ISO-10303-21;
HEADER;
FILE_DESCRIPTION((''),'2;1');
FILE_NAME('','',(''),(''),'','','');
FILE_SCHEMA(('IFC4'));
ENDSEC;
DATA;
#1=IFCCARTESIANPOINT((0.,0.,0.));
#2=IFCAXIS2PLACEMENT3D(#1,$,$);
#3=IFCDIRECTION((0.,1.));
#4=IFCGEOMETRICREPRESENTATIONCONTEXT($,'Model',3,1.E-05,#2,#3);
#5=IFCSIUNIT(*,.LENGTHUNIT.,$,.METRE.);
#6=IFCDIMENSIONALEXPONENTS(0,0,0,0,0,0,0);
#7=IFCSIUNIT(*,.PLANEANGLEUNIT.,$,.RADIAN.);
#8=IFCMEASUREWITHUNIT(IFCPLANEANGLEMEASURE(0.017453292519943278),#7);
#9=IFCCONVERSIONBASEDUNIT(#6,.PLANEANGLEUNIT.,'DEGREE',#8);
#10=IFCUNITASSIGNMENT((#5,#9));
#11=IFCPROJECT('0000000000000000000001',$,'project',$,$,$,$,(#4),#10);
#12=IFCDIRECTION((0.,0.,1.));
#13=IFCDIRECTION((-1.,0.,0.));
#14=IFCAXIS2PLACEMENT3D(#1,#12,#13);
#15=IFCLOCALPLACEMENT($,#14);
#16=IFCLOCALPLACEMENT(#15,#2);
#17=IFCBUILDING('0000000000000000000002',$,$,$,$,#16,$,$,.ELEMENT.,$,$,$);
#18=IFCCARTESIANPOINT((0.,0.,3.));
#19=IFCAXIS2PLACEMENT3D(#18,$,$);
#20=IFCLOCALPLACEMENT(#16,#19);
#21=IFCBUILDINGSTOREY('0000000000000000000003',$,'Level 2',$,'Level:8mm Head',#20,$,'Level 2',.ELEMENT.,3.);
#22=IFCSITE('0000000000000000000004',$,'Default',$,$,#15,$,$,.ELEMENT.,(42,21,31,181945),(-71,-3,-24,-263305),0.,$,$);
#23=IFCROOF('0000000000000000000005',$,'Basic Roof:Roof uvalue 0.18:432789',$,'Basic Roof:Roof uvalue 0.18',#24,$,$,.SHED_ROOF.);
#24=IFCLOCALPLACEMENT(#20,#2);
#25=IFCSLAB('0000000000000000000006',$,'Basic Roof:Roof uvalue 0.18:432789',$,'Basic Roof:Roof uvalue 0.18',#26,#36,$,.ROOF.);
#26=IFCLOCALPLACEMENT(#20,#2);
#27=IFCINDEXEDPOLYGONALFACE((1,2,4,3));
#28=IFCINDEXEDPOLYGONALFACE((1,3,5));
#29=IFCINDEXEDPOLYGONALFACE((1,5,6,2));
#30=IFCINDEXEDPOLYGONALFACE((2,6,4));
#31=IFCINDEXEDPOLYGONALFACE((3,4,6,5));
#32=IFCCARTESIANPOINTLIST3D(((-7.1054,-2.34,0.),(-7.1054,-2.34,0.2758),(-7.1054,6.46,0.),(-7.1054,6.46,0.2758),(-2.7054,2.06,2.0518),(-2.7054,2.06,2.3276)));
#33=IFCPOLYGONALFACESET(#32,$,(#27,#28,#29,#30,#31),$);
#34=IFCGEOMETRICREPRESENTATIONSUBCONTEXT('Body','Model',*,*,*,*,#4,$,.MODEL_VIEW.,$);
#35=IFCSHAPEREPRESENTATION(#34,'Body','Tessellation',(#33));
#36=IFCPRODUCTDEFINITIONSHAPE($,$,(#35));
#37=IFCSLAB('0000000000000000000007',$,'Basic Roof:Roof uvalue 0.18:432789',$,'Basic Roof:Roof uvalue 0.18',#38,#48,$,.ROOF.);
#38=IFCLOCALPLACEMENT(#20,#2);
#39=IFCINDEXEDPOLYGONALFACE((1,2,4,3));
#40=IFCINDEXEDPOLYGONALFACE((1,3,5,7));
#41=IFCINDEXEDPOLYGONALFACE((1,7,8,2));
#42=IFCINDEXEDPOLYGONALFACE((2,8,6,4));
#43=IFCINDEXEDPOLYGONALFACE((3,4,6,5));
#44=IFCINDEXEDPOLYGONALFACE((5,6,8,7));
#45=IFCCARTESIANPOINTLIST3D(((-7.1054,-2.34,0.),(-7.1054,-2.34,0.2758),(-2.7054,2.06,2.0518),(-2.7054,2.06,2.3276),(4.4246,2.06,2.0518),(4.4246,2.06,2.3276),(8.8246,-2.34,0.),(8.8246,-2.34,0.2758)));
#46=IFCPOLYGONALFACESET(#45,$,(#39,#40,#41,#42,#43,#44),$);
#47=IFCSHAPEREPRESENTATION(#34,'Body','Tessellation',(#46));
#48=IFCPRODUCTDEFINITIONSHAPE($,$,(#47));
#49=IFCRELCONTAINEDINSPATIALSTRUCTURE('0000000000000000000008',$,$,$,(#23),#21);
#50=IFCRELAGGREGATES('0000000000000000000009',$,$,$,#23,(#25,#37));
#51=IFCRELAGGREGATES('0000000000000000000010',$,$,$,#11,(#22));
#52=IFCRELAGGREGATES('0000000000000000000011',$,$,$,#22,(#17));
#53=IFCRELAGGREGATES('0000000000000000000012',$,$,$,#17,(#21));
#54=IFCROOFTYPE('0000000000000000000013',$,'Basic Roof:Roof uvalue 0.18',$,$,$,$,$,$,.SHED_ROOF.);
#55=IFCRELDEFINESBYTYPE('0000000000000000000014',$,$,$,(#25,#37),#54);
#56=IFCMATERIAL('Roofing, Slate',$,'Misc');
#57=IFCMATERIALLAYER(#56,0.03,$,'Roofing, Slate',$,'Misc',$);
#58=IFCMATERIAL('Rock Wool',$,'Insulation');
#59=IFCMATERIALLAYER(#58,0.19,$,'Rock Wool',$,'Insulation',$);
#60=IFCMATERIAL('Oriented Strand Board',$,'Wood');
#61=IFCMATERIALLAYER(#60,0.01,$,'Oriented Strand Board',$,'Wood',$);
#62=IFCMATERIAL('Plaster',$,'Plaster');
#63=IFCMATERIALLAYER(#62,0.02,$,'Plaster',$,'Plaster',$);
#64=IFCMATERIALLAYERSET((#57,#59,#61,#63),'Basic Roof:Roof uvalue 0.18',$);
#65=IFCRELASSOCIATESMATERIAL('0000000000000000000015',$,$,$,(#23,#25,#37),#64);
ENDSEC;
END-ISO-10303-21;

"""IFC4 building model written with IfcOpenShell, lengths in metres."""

from ifc_helpers import new_model, entity, si_unit, converted_unit, direction, frame, origin, place, context, subcontext, project, spatial, polyline, outline, extrude, material, layer, layer_set, type_object, element, aggregate, save


model = new_model("IFC4")

# Units and contexts
model_context = context("Model", 3, precision=1e-05, world=origin(), true_north=direction((0.0, 1.0)))
body_context = subcontext(model_context, "Body", "Model", "MODEL_VIEW")
ifc_project = project(units=[si_unit("LENGTHUNIT", "METRE"), converted_unit("PLANEANGLEUNIT", "DEGREE", entity("IfcPlaneAngleMeasure", 0.017453292519943278), si_unit("PLANEANGLEUNIT", "RADIAN"), dimensions=[0, 0, 0, 0, 0, 0, 0])], contexts=[model_context])

# Site, building, storey
site_placement = place(None, frame((0.0, 0.0, 0.0), z_axis=(0.0, 0.0, 1.0), x_axis=(-1.0, 0.0, 0.0)))
site = spatial("IfcSite", under=ifc_project, at=site_placement, Name="Default", CompositionType="ELEMENT", RefLatitude=(42, 21, 31, 181945), RefLongitude=(-71, -3, -24, -263305), RefElevation=0.0)
building_placement = place(site_placement, origin())
building = spatial("IfcBuilding", under=site, at=building_placement, CompositionType="ELEMENT")
storey_placement = place(building_placement, frame((0.0, 0.0, 3.0)))
storey = spatial("IfcBuildingStorey", under=building, at=storey_placement, Name="Level 2", ObjectType="Level:8mm Head", LongName="Level 2", CompositionType="ELEMENT", Elevation=3.0)

# Roof, slabs
ifc_material_1 = material(Name="Roofing, Slate", Category="Misc")
ifc_layer_1 = layer(ifc_material_1, 0.03, Name="Roofing, Slate", Category="Misc")
ifc_material_2 = material(Name="Rock Wool", Category="Insulation")
ifc_layer_2 = layer(ifc_material_2, 0.19, Name="Rock Wool", Category="Insulation")
ifc_material_3 = material(Name="Oriented Strand Board", Category="Wood")
ifc_layer_3 = layer(ifc_material_3, 0.01, Name="Oriented Strand Board", Category="Wood")
ifc_material_4 = material(Name="Plaster", Category="Plaster")
ifc_layer_4 = layer(ifc_material_4, 0.02, Name="Plaster", Category="Plaster")
ifc_layer_set = layer_set([ifc_layer_1, ifc_layer_2, ifc_layer_3, ifc_layer_4], Name="Basic Roof:Roof uvalue 0.18")
roof_placement = place(storey_placement, frame((-7.1054, -2.34, 0.0)))
roof = element("IfcRoof", 1, at=roof_placement, inside=storey, material=ifc_layer_set, Name="Basic Roof:Roof uvalue 0.18:432789", ObjectType="Basic Roof:Roof uvalue 0.18", PredefinedType="SHED_ROOF")
roof_type = type_object("IfcRoofType", Name="Basic Roof:Roof uvalue 0.18", PredefinedType="SHED_ROOF")
slab_1_placement = place(roof_placement, origin())
slab_1 = element("IfcSlab", 2, at=slab_1_placement, type_object=roof_type, material=ifc_layer_set, Name="Basic Roof:Roof uvalue 0.18:432789", ObjectType="Basic Roof:Roof uvalue 0.18", PredefinedType="ROOF", context=body_context, shape_type="SweptSolid", body=[
    extrude(outline(polyline([(-2.4274, 4.4), (-2.4274, -4.4), (2.4274, 0.0), (-2.4274, 4.4)])), frame((2.2, 4.4, 1.0259), z_axis=(-0.422618, 0.0, 0.906308), x_axis=(0.906308, 0.0, 0.422618)), (0.422618, 0.0, 0.906308), 0.2758),
])
slab_2_placement = place(roof_placement, origin())
slab_2 = element("IfcSlab", 3, at=slab_2_placement, type_object=roof_type, material=ifc_layer_set, Name="Basic Roof:Roof uvalue 0.18:432789", ObjectType="Basic Roof:Roof uvalue 0.18", PredefinedType="ROOF", context=body_context, shape_type="SweptSolid", body=[
    extrude(outline(polyline([(-7.965, -2.4274), (7.965, -2.4274), (3.565, 2.4274), (-3.565, 2.4274), (-7.965, -2.4274)])), frame((7.965, 2.2, 1.0259), z_axis=(0.0, -0.422618, 0.906308), x_axis=(1.0, 0.0, 0.0)), (0.0, 0.422618, 0.906308), 0.2758),
])
aggregate(roof, [slab_1, slab_2])

save(model, "model.ifc")
